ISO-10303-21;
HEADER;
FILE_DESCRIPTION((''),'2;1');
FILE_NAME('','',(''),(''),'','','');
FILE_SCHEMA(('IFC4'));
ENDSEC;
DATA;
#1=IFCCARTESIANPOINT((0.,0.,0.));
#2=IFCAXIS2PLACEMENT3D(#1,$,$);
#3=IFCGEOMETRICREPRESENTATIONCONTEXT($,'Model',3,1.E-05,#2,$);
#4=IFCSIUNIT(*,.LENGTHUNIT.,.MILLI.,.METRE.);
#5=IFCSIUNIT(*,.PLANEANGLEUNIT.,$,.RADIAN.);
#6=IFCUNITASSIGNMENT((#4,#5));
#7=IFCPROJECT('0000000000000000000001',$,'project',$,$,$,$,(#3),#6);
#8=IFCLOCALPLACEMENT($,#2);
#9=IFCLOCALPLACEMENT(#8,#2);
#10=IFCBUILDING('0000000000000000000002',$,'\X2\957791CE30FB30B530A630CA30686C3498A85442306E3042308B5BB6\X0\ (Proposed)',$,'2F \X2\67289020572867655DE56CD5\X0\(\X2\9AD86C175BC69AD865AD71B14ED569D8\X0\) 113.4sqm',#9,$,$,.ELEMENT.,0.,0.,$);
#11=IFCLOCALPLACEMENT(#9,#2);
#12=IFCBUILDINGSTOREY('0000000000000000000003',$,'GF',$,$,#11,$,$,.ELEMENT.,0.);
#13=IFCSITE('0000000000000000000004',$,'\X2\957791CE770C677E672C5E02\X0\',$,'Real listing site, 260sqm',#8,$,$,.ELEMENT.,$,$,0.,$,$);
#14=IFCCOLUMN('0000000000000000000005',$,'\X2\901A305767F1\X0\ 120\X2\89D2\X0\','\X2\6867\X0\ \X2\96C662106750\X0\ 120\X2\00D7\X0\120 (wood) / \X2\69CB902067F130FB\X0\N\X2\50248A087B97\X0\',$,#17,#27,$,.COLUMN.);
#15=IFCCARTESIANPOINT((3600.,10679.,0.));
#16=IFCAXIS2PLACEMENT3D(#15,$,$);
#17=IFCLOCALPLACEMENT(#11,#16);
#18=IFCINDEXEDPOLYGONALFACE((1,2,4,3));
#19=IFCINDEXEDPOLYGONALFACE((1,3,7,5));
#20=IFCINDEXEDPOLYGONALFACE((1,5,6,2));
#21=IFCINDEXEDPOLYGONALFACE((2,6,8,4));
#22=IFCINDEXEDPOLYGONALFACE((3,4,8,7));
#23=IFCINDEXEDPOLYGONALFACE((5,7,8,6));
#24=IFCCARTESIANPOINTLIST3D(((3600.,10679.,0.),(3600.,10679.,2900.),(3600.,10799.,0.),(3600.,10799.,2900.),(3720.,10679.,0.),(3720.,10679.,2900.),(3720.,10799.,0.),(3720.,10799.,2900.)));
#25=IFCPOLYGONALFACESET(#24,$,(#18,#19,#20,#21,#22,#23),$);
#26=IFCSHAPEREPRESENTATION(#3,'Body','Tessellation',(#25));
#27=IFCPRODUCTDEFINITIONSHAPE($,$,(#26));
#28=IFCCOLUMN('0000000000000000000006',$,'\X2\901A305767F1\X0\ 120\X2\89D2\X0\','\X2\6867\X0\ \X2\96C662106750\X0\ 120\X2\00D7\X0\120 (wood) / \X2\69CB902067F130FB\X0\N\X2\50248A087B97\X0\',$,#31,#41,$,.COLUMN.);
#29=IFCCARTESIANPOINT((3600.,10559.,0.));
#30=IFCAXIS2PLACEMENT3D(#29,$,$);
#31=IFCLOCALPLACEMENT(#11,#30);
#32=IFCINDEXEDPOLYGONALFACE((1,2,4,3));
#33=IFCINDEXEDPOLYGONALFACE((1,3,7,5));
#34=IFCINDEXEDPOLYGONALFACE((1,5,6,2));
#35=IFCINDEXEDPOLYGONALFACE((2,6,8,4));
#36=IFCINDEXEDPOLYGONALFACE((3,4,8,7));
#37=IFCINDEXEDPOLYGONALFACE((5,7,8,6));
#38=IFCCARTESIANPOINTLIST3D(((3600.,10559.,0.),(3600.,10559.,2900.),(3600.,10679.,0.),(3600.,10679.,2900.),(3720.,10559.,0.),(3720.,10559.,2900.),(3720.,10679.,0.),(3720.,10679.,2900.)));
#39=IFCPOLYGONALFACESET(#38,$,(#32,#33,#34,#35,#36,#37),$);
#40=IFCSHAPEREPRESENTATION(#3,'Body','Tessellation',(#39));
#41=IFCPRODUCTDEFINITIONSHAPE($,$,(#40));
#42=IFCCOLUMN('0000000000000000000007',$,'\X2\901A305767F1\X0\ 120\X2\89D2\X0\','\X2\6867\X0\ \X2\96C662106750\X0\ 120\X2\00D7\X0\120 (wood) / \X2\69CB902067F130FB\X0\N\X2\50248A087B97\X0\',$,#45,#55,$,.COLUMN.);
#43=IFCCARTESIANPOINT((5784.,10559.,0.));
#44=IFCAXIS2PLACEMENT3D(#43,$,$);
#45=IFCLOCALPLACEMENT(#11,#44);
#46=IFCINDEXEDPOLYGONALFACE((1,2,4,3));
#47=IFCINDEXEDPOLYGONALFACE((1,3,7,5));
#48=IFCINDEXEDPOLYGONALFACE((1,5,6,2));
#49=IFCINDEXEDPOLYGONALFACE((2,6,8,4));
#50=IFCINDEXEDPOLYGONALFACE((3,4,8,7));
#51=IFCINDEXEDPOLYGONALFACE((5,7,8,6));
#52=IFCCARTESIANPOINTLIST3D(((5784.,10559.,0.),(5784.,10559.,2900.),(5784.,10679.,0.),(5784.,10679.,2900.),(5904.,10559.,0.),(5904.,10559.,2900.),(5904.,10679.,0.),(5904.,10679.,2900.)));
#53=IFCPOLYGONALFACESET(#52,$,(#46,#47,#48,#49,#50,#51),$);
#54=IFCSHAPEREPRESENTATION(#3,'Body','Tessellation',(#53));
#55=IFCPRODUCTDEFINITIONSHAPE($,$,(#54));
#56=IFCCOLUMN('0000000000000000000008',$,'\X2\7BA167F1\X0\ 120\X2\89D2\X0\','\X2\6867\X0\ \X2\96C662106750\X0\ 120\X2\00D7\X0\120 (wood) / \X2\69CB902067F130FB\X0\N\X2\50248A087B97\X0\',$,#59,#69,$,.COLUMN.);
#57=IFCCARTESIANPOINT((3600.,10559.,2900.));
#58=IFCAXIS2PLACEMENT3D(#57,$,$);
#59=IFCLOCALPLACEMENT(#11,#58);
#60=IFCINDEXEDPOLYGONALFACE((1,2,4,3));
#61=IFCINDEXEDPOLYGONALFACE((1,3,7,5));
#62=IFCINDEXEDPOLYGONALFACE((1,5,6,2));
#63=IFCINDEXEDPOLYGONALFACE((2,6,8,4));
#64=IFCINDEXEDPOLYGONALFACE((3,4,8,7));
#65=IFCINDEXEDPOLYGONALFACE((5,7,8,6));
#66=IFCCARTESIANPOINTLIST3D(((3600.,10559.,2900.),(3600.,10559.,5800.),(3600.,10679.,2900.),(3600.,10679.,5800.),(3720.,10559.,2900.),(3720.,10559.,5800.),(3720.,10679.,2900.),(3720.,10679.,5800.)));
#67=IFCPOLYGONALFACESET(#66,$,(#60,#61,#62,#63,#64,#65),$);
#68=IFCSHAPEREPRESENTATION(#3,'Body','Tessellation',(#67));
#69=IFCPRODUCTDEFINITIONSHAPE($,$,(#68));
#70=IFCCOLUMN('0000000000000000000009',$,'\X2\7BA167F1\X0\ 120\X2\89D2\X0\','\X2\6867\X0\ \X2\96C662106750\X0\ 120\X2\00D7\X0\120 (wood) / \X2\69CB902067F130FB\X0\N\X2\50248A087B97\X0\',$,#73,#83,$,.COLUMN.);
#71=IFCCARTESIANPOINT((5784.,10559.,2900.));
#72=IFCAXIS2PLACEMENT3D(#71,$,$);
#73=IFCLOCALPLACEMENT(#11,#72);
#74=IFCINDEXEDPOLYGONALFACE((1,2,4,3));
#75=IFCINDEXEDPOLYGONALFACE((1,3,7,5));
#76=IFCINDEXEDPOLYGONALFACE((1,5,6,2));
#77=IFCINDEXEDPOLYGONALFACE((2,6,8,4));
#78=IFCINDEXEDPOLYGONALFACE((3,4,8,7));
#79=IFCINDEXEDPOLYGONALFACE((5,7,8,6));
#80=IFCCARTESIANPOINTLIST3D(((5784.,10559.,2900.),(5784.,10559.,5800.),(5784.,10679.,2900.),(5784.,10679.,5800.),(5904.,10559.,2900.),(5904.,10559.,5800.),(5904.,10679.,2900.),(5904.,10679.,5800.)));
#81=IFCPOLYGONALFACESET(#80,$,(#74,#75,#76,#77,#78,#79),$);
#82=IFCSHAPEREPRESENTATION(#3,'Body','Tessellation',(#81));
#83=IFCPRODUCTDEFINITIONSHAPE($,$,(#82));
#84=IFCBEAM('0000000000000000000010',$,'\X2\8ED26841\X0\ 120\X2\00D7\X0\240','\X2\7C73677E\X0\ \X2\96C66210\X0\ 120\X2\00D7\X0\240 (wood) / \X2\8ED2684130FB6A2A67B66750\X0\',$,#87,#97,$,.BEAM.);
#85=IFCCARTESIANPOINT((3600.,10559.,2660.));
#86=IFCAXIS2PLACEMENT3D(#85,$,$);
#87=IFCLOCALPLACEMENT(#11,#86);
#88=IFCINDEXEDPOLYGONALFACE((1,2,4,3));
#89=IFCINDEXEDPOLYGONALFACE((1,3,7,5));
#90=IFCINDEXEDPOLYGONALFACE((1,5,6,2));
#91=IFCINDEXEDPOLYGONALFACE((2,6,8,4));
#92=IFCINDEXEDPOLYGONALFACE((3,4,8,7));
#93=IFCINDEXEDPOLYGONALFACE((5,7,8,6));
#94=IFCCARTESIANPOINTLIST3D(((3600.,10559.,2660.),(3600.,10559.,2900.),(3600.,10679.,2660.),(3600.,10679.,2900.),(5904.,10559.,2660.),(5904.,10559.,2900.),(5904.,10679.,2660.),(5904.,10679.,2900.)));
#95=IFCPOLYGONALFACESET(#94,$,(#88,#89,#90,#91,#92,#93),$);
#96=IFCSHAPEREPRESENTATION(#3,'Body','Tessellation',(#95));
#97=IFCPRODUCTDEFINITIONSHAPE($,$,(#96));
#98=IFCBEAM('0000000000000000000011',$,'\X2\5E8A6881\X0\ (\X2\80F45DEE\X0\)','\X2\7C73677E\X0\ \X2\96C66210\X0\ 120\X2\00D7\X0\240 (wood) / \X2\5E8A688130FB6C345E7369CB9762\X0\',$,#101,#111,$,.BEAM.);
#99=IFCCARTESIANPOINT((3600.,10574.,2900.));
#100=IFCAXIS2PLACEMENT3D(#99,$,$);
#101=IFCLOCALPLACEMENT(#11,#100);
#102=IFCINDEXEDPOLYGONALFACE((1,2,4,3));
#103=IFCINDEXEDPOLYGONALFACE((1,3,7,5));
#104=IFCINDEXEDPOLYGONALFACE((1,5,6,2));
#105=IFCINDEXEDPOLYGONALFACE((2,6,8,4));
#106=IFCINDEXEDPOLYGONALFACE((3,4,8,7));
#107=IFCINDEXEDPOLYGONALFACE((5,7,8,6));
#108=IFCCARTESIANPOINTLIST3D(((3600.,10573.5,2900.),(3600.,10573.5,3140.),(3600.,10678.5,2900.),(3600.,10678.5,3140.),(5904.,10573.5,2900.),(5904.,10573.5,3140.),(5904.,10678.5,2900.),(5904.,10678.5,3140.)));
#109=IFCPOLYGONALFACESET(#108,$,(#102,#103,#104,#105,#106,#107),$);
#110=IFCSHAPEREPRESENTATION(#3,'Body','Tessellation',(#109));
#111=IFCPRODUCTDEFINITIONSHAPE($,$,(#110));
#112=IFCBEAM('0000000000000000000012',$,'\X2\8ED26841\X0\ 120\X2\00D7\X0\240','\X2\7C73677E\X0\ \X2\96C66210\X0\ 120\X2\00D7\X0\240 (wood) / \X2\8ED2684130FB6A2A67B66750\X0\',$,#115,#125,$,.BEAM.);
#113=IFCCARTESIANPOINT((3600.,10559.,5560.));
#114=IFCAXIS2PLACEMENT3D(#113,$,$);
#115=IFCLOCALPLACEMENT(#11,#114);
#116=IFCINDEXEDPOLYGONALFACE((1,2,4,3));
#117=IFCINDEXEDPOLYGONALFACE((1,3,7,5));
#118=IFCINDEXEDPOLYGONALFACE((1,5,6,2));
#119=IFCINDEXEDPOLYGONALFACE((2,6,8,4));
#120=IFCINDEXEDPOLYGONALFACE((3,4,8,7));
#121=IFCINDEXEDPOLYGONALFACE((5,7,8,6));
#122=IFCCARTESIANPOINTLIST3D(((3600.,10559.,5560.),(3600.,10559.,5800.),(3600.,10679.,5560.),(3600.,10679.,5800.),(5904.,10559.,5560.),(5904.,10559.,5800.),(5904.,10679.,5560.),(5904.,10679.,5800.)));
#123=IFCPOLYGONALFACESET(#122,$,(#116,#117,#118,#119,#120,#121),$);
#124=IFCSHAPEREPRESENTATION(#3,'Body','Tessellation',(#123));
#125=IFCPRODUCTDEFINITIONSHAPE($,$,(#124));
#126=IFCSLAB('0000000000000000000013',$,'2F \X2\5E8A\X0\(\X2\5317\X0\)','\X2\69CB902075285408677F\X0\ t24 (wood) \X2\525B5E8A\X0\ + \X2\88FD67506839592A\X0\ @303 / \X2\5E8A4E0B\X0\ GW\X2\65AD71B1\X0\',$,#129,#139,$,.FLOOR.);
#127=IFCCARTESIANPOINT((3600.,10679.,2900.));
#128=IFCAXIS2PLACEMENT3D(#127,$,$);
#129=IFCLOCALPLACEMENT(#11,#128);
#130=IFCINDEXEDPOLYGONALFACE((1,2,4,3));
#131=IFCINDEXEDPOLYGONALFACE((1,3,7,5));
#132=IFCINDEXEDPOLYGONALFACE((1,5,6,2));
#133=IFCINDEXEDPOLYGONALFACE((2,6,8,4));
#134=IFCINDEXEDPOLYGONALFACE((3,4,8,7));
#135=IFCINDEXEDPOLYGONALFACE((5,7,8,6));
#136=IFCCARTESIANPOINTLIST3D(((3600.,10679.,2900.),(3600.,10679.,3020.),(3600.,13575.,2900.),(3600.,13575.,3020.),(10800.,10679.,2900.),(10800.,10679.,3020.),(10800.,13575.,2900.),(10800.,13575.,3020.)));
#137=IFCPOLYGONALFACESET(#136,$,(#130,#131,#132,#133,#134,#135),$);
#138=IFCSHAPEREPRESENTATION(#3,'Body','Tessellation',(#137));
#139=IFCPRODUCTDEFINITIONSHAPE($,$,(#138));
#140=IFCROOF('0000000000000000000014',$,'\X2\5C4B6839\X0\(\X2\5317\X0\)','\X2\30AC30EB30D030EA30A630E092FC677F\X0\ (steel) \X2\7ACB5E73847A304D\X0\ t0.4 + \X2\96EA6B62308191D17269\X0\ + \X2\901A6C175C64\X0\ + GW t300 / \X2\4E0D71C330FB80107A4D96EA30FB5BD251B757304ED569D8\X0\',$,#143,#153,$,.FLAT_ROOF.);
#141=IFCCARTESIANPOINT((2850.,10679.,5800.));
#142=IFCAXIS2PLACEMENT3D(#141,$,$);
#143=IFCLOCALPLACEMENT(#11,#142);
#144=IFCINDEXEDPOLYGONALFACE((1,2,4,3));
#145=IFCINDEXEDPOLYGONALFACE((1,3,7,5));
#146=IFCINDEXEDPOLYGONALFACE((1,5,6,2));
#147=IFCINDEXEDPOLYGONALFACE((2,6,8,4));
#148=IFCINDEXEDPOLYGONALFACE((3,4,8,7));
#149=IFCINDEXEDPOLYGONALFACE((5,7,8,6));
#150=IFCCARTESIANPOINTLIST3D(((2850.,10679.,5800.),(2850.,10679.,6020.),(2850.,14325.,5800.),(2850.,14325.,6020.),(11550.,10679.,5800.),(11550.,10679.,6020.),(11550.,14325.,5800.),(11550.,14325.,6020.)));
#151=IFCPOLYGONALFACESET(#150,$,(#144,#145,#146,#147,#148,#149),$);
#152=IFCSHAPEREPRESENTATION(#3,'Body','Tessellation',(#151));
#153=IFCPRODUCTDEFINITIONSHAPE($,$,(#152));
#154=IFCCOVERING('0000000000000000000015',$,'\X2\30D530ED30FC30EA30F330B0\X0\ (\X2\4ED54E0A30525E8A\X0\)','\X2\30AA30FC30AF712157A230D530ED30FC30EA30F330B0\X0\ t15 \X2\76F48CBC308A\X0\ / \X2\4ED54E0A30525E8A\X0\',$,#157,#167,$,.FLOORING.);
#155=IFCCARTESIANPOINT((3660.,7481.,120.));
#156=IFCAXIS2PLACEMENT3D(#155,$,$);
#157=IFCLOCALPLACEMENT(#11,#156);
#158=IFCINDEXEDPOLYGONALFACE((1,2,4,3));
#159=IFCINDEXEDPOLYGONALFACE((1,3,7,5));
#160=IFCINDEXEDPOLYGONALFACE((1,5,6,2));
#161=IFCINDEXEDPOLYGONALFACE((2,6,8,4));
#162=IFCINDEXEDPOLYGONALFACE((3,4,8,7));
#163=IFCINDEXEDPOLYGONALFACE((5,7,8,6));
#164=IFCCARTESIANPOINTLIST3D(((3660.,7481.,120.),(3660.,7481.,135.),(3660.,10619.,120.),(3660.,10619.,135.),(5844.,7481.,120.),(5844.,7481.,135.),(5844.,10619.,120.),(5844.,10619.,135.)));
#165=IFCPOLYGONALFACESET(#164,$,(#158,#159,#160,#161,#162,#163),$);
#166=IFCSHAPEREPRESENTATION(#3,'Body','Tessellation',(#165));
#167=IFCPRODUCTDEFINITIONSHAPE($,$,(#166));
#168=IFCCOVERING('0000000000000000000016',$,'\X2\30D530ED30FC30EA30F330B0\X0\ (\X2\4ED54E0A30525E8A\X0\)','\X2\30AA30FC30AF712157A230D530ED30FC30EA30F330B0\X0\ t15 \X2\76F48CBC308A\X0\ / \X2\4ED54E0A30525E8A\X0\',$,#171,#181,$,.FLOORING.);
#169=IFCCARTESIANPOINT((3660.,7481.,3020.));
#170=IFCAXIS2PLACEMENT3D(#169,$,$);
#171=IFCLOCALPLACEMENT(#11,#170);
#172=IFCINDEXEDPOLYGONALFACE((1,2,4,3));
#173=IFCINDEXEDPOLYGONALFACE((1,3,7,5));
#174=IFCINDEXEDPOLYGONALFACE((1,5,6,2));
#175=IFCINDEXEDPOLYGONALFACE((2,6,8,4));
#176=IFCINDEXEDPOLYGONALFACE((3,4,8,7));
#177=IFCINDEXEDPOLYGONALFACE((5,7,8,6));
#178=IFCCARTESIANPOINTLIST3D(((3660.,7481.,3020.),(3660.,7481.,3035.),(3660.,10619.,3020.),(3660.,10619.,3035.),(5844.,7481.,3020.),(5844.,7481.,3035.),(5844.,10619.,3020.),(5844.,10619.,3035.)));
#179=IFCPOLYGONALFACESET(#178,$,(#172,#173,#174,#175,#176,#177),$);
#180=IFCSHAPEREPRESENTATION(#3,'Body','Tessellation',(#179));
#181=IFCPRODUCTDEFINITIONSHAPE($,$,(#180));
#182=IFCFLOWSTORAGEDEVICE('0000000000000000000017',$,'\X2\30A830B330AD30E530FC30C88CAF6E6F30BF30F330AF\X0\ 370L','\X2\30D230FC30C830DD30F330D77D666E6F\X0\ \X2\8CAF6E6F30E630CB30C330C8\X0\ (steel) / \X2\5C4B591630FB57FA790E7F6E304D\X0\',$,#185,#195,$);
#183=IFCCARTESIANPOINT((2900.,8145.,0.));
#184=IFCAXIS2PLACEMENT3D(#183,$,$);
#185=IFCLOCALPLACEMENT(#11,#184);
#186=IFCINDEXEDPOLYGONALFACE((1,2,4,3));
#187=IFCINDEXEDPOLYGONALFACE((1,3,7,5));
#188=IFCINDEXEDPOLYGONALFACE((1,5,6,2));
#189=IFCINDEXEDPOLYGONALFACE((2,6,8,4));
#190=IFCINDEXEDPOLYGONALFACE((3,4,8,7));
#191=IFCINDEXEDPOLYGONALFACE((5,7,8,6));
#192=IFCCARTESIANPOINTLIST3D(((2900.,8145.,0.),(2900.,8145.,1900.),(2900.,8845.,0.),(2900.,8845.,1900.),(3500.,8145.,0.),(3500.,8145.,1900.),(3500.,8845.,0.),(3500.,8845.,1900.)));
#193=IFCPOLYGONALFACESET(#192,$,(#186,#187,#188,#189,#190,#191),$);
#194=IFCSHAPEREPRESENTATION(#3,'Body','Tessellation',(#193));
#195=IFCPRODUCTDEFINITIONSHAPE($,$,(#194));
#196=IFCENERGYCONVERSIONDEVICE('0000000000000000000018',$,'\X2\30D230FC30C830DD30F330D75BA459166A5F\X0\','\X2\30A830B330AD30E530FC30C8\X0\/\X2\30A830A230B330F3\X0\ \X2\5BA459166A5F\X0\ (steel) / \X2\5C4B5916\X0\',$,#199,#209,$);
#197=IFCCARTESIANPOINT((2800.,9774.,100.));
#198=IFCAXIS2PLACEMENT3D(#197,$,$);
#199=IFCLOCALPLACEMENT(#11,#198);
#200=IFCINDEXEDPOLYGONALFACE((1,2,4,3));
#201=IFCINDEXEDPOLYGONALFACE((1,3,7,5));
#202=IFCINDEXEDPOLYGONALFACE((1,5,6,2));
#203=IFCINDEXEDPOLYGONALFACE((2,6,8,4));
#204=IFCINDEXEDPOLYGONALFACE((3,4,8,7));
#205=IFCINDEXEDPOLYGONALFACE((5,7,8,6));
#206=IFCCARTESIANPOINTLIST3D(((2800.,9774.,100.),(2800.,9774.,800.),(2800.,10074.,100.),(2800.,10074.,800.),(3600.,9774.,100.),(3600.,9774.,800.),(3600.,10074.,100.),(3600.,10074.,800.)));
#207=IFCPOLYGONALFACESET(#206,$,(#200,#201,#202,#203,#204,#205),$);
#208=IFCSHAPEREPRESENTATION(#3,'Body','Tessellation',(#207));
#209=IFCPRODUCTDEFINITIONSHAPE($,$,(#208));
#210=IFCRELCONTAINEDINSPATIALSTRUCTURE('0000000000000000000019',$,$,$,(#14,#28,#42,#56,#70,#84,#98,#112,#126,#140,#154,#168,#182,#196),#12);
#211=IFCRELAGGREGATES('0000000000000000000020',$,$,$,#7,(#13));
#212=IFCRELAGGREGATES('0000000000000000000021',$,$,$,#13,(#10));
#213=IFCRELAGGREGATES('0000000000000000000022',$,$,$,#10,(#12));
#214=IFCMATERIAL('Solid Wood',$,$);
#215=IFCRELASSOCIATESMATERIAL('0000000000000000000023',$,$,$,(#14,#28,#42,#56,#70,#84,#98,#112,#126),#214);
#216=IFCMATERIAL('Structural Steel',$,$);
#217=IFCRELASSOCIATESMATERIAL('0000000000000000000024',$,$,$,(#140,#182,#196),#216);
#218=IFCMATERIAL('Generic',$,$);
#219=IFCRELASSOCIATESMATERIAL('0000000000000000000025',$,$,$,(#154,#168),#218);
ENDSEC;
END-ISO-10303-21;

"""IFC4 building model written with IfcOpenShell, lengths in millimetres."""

from ifc_helpers import new_model, si_unit, frame, frame_2d, origin, place, context, project, spatial, rectangle, extrude, material, element, save


model = new_model("IFC4")

# Units and contexts
model_context = context("Model", 3, precision=1e-05, world=origin())
ifc_project = project(units=[si_unit("LENGTHUNIT", "METRE", prefix="MILLI"), si_unit("PLANEANGLEUNIT", "RADIAN")], contexts=[model_context])

# Site, building, storey
site_placement = place(None, origin())
site = spatial("IfcSite", under=ifc_project, at=site_placement, Name="長野県松本市", ObjectType="Real listing site, 260sqm", CompositionType="ELEMENT", RefElevation=0.0)
building_placement = place(site_placement, origin())
building = spatial("IfcBuilding", under=site, at=building_placement, Name="長野・サウナと水風呂のある家 (Proposed)", ObjectType="2F 木造在来工法(高気密高断熱仕様) 113.4sqm", CompositionType="ELEMENT", ElevationOfRefHeight=0.0, ElevationOfTerrain=0.0)
storey_placement = place(building_placement, origin())
storey = spatial("IfcBuildingStorey", under=building, at=storey_placement, Name="GF", CompositionType="ELEMENT", Elevation=0.0)

# Columns
ifc_material_1 = material(Name="Solid Wood")
column_1_placement = place(storey_placement, frame((3600.0, 10679.0, 0.0)))
element("IfcColumn", 1, at=column_1_placement, inside=storey, material=ifc_material_1, Name="通し柱 120角", Description="桧 集成材 120×120 (wood) / 構造柱・N値計算", PredefinedType="COLUMN", context=model_context, shape_type="SweptSolid", body=[
    extrude(rectangle(XDim=120.0, YDim=120.0, at=frame_2d((60.0, 60.0))), frame((3600.0, 10679.0, 0.0)), (0.0, 0.0, 1.0), 2900.0),
])
column_2_placement = place(storey_placement, frame((3600.0, 10559.0, 0.0)))
element("IfcColumn", 2, at=column_2_placement, inside=storey, material=ifc_material_1, Name="通し柱 120角", Description="桧 集成材 120×120 (wood) / 構造柱・N値計算", PredefinedType="COLUMN", context=model_context, shape_type="SweptSolid", body=[
    extrude(rectangle(XDim=120.0, YDim=120.0, at=frame_2d((60.0, 60.0))), frame((3600.0, 10559.0, 0.0)), (0.0, 0.0, 1.0), 2900.0),
])
column_3_placement = place(storey_placement, frame((5784.0, 10559.0, 0.0)))
element("IfcColumn", 3, at=column_3_placement, inside=storey, material=ifc_material_1, Name="通し柱 120角", Description="桧 集成材 120×120 (wood) / 構造柱・N値計算", PredefinedType="COLUMN", context=model_context, shape_type="SweptSolid", body=[
    extrude(rectangle(XDim=120.0, YDim=120.0, at=frame_2d((60.0, 60.0))), frame((5784.0, 10559.0, 0.0)), (0.0, 0.0, 1.0), 2900.0),
])
column_4_placement = place(storey_placement, frame((3600.0, 10559.0, 2900.0)))
element("IfcColumn", 4, at=column_4_placement, inside=storey, material=ifc_material_1, Name="管柱 120角", Description="桧 集成材 120×120 (wood) / 構造柱・N値計算", PredefinedType="COLUMN", context=model_context, shape_type="SweptSolid", body=[
    extrude(rectangle(XDim=120.0, YDim=120.0, at=frame_2d((60.0, 60.0))), frame((3600.0, 10559.0, 2900.0)), (0.0, 0.0, 1.0), 2900.0),
])
column_5_placement = place(storey_placement, frame((5784.0, 10559.0, 2900.0)))
element("IfcColumn", 5, at=column_5_placement, inside=storey, material=ifc_material_1, Name="管柱 120角", Description="桧 集成材 120×120 (wood) / 構造柱・N値計算", PredefinedType="COLUMN", context=model_context, shape_type="SweptSolid", body=[
    extrude(rectangle(XDim=120.0, YDim=120.0, at=frame_2d((60.0, 60.0))), frame((5784.0, 10559.0, 2900.0)), (0.0, 0.0, 1.0), 2900.0),
])

# Beams
beam_1_placement = place(storey_placement, frame((3600.0, 10559.0, 2660.0)))
element("IfcBeam", 6, at=beam_1_placement, inside=storey, material=ifc_material_1, Name="軒桁 120×240", Description="米松 集成 120×240 (wood) / 軒桁・横架材", PredefinedType="BEAM", context=model_context, shape_type="SweptSolid", body=[
    extrude(rectangle(XDim=2304.0, YDim=120.0, at=frame_2d((1152.0, 60.0))), frame((3600.0, 10559.0, 2660.0)), (0.0, 0.0, 1.0), 240.0),
])
beam_2_placement = place(storey_placement, frame((3600.0, 10574.0, 2900.0)))
element("IfcBeam", 7, at=beam_2_placement, inside=storey, material=ifc_material_1, Name="床梁 (胴差)", Description="米松 集成 120×240 (wood) / 床梁・水平構面", PredefinedType="BEAM", context=model_context, shape_type="SweptSolid", body=[
    extrude(rectangle(XDim=2304.0, YDim=105.0, at=frame_2d((1152.0, 52.0))), frame((3600.0, 10574.0, 2900.0)), (0.0, 0.0, 1.0), 240.0),
])
beam_3_placement = place(storey_placement, frame((3600.0, 10559.0, 5560.0)))
element("IfcBeam", 8, at=beam_3_placement, inside=storey, material=ifc_material_1, Name="軒桁 120×240", Description="米松 集成 120×240 (wood) / 軒桁・横架材", PredefinedType="BEAM", context=model_context, shape_type="SweptSolid", body=[
    extrude(rectangle(XDim=2304.0, YDim=120.0, at=frame_2d((1152.0, 60.0))), frame((3600.0, 10559.0, 5560.0)), (0.0, 0.0, 1.0), 240.0),
])

# Slab
slab_1_placement = place(storey_placement, frame((3600.0, 10679.0, 2900.0)))
element("IfcSlab", 9, at=slab_1_placement, inside=storey, material=ifc_material_1, Name="2F 床(北)", Description="構造用合板 t24 (wood) 剛床 + 製材根太 @303 / 床下 GW断熱", PredefinedType="FLOOR", context=model_context, shape_type="SweptSolid", body=[
    extrude(rectangle(XDim=7200.0, YDim=2896.0, at=frame_2d((3600.0, 1448.0))), frame((3600.0, 10679.0, 2900.0)), (0.0, 0.0, 1.0), 120.0),
])

# Roof
ifc_material_2 = material(Name="Structural Steel")
for number, where, name in (
    (10, (2850.0, 10679.0, 5800.0), "屋根(北)"),
):
    element("IfcRoof", number, at=place(storey_placement, frame(where)), inside=storey, material=ifc_material_2, Name=name, Description="ガルバリウム鋼板 (steel) 立平葺き t0.4 + 雪止め金物 + 通気層 + GW t300 / 不燃・耐積雪・寒冷地仕様", PredefinedType="FLAT_ROOF", context=model_context, shape_type="SweptSolid", body=[
        extrude(rectangle(XDim=8700.0, YDim=3646.0, at=frame_2d((4350.0, 1823.0))), frame((2850.0, 10679.0, 5800.0)), (0.0, 0.0, 1.0), 220.0),
    ])

# Coverings
ifc_material_3 = material(Name="Generic")
covering_1_placement = place(storey_placement, frame((3660.0, 7481.0, 120.0)))
element("IfcCovering", 11, at=covering_1_placement, inside=storey, material=ifc_material_3, Name="フローリング (仕上げ床)", Description="オーク無垢フローリング t15 直貼り / 仕上げ床", PredefinedType="FLOORING", context=model_context, shape_type="SweptSolid", body=[
    extrude(rectangle(XDim=2184.0, YDim=3138.0, at=frame_2d((1092.0, 1569.0))), frame((3660.0, 7481.0, 120.0)), (0.0, 0.0, 1.0), 15.0),
])
covering_2_placement = place(storey_placement, frame((3660.0, 7481.0, 3020.0)))
element("IfcCovering", 12, at=covering_2_placement, inside=storey, material=ifc_material_3, Name="フローリング (仕上げ床)", Description="オーク無垢フローリング t15 直貼り / 仕上げ床", PredefinedType="FLOORING", context=model_context, shape_type="SweptSolid", body=[
    extrude(rectangle(XDim=2184.0, YDim=3138.0, at=frame_2d((1092.0, 1569.0))), frame((3660.0, 7481.0, 3020.0)), (0.0, 0.0, 1.0), 15.0),
])

# Flow storage device
flow_storage_device_placement = place(storey_placement, frame((2900.0, 8145.0, 0.0)))
element("IfcFlowStorageDevice", 13, at=flow_storage_device_placement, inside=storey, material=ifc_material_2, Name="エコキュート貯湯タンク 370L", Description="ヒートポンプ給湯 貯湯ユニット (steel) / 屋外・基礎置き", context=model_context, shape_type="SweptSolid", body=[
    extrude(rectangle(XDim=600.0, YDim=700.0, at=frame_2d((300.0, 350.0))), frame((2900.0, 8145.0, 0.0)), (0.0, 0.0, 1.0), 1900.0),
])

# Energy conversion device
energy_conversion_device_placement = place(storey_placement, frame((2800.0, 9774.0, 100.0)))
element("IfcEnergyConversionDevice", 14, at=energy_conversion_device_placement, inside=storey, material=ifc_material_2, Name="ヒートポンプ室外機", Description="エコキュート/エアコン 室外機 (steel) / 屋外", context=model_context, shape_type="SweptSolid", body=[
    extrude(rectangle(XDim=800.0, YDim=300.0, at=frame_2d((400.0, 150.0))), frame((2800.0, 9774.0, 100.0)), (0.0, 0.0, 1.0), 700.0),
])

save(model, "model.ifc")
